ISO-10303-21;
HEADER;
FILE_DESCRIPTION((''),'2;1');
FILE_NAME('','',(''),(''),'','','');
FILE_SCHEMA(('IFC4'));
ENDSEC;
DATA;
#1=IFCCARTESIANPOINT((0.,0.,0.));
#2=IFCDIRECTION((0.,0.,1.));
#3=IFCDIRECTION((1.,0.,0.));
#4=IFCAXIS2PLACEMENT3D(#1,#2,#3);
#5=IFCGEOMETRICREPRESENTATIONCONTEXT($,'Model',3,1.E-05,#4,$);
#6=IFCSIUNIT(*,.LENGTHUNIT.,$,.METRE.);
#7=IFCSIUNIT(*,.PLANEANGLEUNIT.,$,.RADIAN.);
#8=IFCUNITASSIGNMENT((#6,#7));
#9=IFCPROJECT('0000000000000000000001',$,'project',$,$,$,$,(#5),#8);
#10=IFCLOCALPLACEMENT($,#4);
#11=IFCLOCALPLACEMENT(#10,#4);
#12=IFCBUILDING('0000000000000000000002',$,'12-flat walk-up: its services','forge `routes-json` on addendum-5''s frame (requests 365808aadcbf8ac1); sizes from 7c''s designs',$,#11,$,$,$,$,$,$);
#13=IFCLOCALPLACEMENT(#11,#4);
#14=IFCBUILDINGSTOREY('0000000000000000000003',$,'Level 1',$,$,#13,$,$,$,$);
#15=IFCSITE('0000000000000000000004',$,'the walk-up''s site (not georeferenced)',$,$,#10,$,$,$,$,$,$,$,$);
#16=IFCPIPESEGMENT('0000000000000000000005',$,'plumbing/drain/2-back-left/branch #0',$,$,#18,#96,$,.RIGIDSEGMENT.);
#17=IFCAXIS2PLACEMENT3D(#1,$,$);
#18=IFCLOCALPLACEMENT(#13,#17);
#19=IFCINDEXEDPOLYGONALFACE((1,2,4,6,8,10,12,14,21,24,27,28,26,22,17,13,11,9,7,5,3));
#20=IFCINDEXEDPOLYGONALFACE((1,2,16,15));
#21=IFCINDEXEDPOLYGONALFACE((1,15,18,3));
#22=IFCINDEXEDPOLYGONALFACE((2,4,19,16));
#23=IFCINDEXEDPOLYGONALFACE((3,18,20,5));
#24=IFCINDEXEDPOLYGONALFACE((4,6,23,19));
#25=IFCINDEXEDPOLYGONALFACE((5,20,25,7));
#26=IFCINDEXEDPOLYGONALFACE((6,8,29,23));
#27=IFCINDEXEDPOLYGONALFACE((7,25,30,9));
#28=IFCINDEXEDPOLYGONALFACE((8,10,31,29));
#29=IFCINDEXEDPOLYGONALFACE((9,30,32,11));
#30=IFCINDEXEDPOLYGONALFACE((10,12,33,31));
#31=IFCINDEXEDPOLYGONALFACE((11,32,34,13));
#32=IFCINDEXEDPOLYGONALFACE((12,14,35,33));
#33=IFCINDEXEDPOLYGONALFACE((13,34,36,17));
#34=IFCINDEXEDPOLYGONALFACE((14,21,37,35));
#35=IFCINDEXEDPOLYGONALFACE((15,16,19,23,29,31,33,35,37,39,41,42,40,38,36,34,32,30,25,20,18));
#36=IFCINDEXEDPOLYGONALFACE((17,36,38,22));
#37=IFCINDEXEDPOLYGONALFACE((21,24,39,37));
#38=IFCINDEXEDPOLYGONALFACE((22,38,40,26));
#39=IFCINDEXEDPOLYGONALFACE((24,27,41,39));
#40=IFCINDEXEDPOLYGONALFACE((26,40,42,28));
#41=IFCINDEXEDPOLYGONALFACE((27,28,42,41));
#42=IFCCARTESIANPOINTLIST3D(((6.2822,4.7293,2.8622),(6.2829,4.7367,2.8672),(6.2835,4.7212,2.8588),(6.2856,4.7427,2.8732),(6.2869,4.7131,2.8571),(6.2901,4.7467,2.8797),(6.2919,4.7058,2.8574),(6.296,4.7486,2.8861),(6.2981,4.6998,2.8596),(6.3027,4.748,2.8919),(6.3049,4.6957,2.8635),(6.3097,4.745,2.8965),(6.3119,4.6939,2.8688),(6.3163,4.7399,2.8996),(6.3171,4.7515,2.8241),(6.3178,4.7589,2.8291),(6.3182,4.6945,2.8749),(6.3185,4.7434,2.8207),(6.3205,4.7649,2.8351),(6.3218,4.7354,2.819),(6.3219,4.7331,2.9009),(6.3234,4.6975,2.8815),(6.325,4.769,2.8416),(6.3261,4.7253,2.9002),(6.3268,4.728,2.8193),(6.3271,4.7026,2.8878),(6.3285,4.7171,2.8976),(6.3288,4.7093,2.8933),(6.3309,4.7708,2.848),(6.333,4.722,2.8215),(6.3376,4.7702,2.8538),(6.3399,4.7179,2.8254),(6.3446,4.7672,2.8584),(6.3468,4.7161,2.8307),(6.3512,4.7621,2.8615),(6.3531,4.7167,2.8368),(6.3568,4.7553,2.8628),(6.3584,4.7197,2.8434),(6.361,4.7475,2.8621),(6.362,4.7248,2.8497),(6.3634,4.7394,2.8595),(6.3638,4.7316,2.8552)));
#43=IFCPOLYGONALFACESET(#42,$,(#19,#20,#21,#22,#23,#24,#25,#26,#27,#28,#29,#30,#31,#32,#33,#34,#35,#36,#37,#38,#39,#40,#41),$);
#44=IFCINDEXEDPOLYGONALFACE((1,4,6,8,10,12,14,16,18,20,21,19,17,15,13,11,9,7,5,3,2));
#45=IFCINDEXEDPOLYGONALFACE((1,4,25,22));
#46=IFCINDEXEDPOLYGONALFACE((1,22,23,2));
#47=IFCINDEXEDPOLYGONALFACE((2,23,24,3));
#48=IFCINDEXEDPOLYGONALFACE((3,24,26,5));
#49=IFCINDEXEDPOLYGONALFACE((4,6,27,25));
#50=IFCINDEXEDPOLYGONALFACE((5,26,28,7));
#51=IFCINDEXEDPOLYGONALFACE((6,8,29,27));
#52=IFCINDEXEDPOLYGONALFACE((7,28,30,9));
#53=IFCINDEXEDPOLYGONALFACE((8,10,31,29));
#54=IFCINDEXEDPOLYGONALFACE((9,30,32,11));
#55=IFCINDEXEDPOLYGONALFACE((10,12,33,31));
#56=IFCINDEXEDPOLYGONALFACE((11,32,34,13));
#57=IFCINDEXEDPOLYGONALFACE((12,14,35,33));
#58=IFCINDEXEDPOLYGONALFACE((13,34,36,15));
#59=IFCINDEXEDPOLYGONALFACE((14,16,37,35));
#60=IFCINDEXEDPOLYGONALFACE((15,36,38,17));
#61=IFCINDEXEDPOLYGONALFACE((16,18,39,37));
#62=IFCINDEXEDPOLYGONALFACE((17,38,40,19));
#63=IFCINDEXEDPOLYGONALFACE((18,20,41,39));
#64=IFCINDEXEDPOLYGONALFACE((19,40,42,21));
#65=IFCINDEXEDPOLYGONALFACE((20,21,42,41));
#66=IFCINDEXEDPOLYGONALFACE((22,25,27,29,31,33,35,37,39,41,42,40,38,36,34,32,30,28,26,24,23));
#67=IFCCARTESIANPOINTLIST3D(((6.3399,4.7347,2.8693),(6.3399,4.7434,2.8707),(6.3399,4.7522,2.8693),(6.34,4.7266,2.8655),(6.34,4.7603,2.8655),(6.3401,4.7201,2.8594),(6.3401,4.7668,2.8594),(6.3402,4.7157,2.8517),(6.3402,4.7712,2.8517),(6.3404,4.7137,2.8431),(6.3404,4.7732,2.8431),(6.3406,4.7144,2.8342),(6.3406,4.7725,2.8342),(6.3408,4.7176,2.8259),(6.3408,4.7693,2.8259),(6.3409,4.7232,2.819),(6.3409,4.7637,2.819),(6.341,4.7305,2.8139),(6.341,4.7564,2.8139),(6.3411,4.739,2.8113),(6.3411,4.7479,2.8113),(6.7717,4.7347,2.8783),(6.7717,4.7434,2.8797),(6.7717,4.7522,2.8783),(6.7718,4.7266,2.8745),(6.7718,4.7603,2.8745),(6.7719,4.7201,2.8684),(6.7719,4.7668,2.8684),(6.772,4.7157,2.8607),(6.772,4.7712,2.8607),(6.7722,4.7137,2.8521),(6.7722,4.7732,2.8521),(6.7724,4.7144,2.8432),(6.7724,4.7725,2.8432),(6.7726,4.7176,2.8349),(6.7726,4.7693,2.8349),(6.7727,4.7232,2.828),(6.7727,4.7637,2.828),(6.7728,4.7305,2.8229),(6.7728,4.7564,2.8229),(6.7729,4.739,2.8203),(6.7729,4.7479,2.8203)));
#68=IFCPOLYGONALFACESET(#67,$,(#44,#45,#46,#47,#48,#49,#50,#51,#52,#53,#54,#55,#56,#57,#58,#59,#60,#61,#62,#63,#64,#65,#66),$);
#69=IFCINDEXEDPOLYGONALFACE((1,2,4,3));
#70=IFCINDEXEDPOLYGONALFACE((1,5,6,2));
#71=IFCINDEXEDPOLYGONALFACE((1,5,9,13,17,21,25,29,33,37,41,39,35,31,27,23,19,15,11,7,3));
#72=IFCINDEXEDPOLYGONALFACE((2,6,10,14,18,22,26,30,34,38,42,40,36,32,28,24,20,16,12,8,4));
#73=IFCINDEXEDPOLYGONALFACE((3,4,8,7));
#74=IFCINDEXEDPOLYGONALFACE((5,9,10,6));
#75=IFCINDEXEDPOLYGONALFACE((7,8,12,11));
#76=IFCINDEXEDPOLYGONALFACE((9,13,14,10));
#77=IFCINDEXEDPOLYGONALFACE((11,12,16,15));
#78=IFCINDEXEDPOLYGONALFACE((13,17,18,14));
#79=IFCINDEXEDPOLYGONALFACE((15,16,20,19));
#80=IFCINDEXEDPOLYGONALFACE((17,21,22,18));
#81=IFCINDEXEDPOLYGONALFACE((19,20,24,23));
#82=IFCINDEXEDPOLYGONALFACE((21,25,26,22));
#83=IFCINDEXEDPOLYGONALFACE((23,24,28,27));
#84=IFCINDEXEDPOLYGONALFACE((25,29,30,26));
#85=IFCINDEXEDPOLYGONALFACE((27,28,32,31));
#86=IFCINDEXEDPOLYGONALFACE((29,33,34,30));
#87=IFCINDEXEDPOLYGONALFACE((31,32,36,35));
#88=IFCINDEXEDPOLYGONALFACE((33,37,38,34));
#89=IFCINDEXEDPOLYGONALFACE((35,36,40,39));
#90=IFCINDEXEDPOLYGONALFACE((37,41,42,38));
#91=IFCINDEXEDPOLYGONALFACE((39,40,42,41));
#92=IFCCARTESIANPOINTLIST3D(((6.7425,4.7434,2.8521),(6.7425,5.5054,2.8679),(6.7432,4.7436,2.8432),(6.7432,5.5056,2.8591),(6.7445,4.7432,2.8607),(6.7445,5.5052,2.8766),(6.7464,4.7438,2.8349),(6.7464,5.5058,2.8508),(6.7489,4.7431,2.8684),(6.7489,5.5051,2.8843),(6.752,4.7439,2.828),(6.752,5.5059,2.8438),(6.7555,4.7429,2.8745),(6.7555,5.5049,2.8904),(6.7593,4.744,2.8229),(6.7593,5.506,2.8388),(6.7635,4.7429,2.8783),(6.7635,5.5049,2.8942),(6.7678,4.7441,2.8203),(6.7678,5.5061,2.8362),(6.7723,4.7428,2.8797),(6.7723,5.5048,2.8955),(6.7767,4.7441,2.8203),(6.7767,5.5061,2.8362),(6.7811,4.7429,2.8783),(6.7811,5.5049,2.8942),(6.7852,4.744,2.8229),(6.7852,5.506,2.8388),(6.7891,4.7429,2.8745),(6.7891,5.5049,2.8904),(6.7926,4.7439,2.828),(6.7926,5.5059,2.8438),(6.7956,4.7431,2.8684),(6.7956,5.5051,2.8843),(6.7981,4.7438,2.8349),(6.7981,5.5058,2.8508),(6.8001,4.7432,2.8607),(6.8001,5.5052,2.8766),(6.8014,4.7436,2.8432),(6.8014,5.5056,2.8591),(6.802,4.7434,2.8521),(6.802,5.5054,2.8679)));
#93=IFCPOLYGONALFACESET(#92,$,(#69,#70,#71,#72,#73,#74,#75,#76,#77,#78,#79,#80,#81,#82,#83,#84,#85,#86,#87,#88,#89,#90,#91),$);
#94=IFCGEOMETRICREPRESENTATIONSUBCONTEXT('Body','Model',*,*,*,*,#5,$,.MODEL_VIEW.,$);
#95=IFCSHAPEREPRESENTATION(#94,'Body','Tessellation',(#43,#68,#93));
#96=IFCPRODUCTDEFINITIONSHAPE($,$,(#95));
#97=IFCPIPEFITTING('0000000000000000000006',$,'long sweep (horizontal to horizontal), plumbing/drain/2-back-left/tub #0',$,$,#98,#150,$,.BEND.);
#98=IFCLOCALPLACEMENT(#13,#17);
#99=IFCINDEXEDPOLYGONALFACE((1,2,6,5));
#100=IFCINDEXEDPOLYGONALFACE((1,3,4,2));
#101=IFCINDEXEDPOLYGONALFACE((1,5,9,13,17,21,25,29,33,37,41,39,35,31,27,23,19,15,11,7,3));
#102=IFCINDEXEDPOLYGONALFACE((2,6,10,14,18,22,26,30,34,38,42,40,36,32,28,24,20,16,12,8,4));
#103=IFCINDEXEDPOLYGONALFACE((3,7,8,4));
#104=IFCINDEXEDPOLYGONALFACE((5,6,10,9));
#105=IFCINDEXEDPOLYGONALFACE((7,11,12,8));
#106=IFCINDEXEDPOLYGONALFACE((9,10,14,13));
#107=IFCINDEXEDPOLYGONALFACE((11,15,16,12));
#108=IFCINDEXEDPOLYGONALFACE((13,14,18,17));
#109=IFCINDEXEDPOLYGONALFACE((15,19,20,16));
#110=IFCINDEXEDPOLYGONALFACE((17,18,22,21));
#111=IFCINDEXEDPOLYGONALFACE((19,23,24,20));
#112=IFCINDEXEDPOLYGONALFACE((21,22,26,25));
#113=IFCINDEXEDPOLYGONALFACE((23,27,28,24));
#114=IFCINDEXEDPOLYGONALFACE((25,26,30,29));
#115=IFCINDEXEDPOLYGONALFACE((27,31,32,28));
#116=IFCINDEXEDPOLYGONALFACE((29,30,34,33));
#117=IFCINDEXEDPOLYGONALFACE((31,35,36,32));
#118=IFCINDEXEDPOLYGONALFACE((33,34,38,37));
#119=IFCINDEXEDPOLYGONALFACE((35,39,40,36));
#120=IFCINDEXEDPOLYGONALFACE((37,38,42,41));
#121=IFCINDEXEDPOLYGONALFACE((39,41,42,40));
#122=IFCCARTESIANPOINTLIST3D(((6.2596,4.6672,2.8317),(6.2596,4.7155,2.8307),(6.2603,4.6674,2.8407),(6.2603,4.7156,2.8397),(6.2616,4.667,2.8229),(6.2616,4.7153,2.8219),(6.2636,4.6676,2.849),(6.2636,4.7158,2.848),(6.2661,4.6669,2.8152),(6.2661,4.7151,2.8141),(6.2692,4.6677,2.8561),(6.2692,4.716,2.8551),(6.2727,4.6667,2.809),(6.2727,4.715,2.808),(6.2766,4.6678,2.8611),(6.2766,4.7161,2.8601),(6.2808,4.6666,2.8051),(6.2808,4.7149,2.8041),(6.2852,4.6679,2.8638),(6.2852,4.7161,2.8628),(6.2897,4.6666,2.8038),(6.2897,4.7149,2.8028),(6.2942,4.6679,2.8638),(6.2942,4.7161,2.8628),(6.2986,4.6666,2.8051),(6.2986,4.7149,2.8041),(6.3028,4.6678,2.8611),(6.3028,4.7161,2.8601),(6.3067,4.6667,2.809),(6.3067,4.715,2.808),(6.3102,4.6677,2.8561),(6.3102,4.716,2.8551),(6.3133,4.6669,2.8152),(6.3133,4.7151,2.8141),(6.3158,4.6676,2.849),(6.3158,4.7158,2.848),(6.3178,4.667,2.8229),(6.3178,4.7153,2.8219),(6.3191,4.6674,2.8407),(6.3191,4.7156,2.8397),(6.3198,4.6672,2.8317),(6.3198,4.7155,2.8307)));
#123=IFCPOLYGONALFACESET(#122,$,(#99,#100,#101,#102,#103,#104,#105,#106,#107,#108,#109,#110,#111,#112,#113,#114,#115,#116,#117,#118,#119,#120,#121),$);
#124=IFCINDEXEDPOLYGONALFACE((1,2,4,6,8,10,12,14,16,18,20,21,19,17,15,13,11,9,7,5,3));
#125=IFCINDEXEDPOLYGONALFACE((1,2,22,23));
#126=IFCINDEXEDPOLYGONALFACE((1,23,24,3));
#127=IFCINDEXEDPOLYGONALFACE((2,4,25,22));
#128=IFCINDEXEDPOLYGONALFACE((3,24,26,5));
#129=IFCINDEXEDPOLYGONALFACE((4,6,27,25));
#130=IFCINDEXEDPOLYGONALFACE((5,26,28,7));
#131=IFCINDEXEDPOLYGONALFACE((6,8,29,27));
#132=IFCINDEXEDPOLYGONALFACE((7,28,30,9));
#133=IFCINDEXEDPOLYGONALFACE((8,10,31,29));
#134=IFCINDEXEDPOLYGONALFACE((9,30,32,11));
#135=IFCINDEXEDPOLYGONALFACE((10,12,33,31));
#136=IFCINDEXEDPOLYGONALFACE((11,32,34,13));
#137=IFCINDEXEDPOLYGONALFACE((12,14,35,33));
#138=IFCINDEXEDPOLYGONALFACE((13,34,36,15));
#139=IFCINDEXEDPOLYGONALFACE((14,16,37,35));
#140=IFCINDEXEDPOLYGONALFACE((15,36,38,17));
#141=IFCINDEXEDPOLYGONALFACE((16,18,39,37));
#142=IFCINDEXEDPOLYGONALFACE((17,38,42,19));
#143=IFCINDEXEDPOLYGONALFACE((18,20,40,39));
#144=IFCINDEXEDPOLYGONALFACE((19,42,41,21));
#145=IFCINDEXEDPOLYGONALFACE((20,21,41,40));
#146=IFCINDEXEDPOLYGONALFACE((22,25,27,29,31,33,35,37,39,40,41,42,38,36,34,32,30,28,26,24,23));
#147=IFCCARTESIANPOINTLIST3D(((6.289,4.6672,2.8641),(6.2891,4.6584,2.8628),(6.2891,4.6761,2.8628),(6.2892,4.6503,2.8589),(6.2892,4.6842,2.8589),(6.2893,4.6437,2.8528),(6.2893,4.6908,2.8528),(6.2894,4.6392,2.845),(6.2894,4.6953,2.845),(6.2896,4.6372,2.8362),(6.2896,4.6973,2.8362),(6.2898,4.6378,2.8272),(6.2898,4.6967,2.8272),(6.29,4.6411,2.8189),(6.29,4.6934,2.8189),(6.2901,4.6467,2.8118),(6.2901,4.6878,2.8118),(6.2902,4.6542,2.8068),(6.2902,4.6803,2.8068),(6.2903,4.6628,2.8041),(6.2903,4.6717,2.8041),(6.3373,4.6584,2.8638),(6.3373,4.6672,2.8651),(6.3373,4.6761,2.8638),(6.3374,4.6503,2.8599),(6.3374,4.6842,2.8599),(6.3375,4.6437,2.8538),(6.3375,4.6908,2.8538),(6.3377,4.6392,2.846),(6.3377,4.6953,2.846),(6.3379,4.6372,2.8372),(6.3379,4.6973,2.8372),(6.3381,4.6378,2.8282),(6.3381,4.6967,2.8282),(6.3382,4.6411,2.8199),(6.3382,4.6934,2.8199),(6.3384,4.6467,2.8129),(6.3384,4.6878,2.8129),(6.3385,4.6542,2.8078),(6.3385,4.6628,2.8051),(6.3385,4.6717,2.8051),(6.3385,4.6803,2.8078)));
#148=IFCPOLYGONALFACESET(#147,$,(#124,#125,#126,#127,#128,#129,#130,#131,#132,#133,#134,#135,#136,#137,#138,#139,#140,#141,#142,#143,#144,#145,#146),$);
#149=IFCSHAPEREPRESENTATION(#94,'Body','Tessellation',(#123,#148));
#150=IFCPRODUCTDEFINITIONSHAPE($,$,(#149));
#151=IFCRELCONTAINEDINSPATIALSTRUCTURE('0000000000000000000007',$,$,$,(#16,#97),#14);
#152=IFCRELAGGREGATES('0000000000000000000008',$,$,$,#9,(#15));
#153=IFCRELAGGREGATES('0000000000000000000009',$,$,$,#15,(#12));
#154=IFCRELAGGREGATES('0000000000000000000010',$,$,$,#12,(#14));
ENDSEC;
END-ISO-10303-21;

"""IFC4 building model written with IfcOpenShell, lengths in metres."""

from ifc_helpers import new_model, entity, si_unit, frame, origin_with_axes, place, context, subcontext, project, spatial, element, save


model = new_model("IFC4")

# Units and contexts
model_context = context("Model", 3, precision=1e-05, world=origin_with_axes())
body_context = subcontext(model_context, "Body", "Model", "MODEL_VIEW")
ifc_project = project(units=[si_unit("LENGTHUNIT", "METRE"), si_unit("PLANEANGLEUNIT", "RADIAN")], contexts=[model_context])

# Site, building, storey
site_placement = place(None, origin_with_axes())
site = spatial("IfcSite", under=ifc_project, at=site_placement, Name="the walk-up's site (not georeferenced)")
building_placement = place(site_placement, origin_with_axes())
building = spatial("IfcBuilding", under=site, at=building_placement, Name="12-flat walk-up: its services", Description="forge `routes-json` on addendum-5's frame (requests 365808aadcbf8ac1); sizes from 7c's designs")
storey_placement = place(building_placement, origin_with_axes())
storey = spatial("IfcBuildingStorey", under=building, at=storey_placement, Name="Level 1")

# Pipe segment
pipe_segment_1_placement = place(storey_placement, frame((6.3056, 4.7212, 2.8789), z_axis=(0.0, 0.0, 1.0), x_axis=(1.0, 0.0, 0.0)))
element("IfcPipeSegment", 1, at=pipe_segment_1_placement, inside=storey, Name="plumbing/drain/2-back-left/branch #0", PredefinedType="RIGIDSEGMENT", context=body_context, shape_type="AdvancedSweptSolid", body=[
    entity("IfcSweptDiskSolid", entity("IfcPolyline", [entity("IfcCartesianPoint", [0.0, 0.0, 0.0]), entity("IfcCartesianPoint", [0.0349, 0.0222, -0.0381])]), 0.0298),
    entity("IfcSweptDiskSolid", entity("IfcPolyline", [entity("IfcCartesianPoint", [0.0349, 0.0222, -0.0381]), entity("IfcCartesianPoint", [0.4667, 0.0222, -0.0291])]), 0.0298),
    entity("IfcSweptDiskSolid", entity("IfcPolyline", [entity("IfcCartesianPoint", [0.4667, 0.0222, -0.0291]), entity("IfcCartesianPoint", [0.4667, 0.7842, -0.0132])]), 0.0298),
])

# Pipe fitting
pipe_fitting_1_placement = place(storey_placement, frame((6.2897, 4.7155, 2.8329), z_axis=(0.0, 0.0, 1.0), x_axis=(1.0, 0.0, 0.0)))
element("IfcPipeFitting", 2, at=pipe_fitting_1_placement, inside=storey, Name="long sweep (horizontal to horizontal), plumbing/drain/2-back-left/tub #0", PredefinedType="BEND", context=body_context, shape_type="AdvancedSweptSolid", body=[
    entity("IfcSweptDiskSolid", entity("IfcPolyline", [entity("IfcCartesianPoint", [0.0, 0.0, 0.0]), entity("IfcCartesianPoint", [0.0, -0.0482, 0.001])]), 0.0302),
    entity("IfcSweptDiskSolid", entity("IfcPolyline", [entity("IfcCartesianPoint", [0.0, -0.0482, 0.001]), entity("IfcCartesianPoint", [0.0482, -0.0482, 0.002])]), 0.0302),
])

save(model, "model.ifc")
